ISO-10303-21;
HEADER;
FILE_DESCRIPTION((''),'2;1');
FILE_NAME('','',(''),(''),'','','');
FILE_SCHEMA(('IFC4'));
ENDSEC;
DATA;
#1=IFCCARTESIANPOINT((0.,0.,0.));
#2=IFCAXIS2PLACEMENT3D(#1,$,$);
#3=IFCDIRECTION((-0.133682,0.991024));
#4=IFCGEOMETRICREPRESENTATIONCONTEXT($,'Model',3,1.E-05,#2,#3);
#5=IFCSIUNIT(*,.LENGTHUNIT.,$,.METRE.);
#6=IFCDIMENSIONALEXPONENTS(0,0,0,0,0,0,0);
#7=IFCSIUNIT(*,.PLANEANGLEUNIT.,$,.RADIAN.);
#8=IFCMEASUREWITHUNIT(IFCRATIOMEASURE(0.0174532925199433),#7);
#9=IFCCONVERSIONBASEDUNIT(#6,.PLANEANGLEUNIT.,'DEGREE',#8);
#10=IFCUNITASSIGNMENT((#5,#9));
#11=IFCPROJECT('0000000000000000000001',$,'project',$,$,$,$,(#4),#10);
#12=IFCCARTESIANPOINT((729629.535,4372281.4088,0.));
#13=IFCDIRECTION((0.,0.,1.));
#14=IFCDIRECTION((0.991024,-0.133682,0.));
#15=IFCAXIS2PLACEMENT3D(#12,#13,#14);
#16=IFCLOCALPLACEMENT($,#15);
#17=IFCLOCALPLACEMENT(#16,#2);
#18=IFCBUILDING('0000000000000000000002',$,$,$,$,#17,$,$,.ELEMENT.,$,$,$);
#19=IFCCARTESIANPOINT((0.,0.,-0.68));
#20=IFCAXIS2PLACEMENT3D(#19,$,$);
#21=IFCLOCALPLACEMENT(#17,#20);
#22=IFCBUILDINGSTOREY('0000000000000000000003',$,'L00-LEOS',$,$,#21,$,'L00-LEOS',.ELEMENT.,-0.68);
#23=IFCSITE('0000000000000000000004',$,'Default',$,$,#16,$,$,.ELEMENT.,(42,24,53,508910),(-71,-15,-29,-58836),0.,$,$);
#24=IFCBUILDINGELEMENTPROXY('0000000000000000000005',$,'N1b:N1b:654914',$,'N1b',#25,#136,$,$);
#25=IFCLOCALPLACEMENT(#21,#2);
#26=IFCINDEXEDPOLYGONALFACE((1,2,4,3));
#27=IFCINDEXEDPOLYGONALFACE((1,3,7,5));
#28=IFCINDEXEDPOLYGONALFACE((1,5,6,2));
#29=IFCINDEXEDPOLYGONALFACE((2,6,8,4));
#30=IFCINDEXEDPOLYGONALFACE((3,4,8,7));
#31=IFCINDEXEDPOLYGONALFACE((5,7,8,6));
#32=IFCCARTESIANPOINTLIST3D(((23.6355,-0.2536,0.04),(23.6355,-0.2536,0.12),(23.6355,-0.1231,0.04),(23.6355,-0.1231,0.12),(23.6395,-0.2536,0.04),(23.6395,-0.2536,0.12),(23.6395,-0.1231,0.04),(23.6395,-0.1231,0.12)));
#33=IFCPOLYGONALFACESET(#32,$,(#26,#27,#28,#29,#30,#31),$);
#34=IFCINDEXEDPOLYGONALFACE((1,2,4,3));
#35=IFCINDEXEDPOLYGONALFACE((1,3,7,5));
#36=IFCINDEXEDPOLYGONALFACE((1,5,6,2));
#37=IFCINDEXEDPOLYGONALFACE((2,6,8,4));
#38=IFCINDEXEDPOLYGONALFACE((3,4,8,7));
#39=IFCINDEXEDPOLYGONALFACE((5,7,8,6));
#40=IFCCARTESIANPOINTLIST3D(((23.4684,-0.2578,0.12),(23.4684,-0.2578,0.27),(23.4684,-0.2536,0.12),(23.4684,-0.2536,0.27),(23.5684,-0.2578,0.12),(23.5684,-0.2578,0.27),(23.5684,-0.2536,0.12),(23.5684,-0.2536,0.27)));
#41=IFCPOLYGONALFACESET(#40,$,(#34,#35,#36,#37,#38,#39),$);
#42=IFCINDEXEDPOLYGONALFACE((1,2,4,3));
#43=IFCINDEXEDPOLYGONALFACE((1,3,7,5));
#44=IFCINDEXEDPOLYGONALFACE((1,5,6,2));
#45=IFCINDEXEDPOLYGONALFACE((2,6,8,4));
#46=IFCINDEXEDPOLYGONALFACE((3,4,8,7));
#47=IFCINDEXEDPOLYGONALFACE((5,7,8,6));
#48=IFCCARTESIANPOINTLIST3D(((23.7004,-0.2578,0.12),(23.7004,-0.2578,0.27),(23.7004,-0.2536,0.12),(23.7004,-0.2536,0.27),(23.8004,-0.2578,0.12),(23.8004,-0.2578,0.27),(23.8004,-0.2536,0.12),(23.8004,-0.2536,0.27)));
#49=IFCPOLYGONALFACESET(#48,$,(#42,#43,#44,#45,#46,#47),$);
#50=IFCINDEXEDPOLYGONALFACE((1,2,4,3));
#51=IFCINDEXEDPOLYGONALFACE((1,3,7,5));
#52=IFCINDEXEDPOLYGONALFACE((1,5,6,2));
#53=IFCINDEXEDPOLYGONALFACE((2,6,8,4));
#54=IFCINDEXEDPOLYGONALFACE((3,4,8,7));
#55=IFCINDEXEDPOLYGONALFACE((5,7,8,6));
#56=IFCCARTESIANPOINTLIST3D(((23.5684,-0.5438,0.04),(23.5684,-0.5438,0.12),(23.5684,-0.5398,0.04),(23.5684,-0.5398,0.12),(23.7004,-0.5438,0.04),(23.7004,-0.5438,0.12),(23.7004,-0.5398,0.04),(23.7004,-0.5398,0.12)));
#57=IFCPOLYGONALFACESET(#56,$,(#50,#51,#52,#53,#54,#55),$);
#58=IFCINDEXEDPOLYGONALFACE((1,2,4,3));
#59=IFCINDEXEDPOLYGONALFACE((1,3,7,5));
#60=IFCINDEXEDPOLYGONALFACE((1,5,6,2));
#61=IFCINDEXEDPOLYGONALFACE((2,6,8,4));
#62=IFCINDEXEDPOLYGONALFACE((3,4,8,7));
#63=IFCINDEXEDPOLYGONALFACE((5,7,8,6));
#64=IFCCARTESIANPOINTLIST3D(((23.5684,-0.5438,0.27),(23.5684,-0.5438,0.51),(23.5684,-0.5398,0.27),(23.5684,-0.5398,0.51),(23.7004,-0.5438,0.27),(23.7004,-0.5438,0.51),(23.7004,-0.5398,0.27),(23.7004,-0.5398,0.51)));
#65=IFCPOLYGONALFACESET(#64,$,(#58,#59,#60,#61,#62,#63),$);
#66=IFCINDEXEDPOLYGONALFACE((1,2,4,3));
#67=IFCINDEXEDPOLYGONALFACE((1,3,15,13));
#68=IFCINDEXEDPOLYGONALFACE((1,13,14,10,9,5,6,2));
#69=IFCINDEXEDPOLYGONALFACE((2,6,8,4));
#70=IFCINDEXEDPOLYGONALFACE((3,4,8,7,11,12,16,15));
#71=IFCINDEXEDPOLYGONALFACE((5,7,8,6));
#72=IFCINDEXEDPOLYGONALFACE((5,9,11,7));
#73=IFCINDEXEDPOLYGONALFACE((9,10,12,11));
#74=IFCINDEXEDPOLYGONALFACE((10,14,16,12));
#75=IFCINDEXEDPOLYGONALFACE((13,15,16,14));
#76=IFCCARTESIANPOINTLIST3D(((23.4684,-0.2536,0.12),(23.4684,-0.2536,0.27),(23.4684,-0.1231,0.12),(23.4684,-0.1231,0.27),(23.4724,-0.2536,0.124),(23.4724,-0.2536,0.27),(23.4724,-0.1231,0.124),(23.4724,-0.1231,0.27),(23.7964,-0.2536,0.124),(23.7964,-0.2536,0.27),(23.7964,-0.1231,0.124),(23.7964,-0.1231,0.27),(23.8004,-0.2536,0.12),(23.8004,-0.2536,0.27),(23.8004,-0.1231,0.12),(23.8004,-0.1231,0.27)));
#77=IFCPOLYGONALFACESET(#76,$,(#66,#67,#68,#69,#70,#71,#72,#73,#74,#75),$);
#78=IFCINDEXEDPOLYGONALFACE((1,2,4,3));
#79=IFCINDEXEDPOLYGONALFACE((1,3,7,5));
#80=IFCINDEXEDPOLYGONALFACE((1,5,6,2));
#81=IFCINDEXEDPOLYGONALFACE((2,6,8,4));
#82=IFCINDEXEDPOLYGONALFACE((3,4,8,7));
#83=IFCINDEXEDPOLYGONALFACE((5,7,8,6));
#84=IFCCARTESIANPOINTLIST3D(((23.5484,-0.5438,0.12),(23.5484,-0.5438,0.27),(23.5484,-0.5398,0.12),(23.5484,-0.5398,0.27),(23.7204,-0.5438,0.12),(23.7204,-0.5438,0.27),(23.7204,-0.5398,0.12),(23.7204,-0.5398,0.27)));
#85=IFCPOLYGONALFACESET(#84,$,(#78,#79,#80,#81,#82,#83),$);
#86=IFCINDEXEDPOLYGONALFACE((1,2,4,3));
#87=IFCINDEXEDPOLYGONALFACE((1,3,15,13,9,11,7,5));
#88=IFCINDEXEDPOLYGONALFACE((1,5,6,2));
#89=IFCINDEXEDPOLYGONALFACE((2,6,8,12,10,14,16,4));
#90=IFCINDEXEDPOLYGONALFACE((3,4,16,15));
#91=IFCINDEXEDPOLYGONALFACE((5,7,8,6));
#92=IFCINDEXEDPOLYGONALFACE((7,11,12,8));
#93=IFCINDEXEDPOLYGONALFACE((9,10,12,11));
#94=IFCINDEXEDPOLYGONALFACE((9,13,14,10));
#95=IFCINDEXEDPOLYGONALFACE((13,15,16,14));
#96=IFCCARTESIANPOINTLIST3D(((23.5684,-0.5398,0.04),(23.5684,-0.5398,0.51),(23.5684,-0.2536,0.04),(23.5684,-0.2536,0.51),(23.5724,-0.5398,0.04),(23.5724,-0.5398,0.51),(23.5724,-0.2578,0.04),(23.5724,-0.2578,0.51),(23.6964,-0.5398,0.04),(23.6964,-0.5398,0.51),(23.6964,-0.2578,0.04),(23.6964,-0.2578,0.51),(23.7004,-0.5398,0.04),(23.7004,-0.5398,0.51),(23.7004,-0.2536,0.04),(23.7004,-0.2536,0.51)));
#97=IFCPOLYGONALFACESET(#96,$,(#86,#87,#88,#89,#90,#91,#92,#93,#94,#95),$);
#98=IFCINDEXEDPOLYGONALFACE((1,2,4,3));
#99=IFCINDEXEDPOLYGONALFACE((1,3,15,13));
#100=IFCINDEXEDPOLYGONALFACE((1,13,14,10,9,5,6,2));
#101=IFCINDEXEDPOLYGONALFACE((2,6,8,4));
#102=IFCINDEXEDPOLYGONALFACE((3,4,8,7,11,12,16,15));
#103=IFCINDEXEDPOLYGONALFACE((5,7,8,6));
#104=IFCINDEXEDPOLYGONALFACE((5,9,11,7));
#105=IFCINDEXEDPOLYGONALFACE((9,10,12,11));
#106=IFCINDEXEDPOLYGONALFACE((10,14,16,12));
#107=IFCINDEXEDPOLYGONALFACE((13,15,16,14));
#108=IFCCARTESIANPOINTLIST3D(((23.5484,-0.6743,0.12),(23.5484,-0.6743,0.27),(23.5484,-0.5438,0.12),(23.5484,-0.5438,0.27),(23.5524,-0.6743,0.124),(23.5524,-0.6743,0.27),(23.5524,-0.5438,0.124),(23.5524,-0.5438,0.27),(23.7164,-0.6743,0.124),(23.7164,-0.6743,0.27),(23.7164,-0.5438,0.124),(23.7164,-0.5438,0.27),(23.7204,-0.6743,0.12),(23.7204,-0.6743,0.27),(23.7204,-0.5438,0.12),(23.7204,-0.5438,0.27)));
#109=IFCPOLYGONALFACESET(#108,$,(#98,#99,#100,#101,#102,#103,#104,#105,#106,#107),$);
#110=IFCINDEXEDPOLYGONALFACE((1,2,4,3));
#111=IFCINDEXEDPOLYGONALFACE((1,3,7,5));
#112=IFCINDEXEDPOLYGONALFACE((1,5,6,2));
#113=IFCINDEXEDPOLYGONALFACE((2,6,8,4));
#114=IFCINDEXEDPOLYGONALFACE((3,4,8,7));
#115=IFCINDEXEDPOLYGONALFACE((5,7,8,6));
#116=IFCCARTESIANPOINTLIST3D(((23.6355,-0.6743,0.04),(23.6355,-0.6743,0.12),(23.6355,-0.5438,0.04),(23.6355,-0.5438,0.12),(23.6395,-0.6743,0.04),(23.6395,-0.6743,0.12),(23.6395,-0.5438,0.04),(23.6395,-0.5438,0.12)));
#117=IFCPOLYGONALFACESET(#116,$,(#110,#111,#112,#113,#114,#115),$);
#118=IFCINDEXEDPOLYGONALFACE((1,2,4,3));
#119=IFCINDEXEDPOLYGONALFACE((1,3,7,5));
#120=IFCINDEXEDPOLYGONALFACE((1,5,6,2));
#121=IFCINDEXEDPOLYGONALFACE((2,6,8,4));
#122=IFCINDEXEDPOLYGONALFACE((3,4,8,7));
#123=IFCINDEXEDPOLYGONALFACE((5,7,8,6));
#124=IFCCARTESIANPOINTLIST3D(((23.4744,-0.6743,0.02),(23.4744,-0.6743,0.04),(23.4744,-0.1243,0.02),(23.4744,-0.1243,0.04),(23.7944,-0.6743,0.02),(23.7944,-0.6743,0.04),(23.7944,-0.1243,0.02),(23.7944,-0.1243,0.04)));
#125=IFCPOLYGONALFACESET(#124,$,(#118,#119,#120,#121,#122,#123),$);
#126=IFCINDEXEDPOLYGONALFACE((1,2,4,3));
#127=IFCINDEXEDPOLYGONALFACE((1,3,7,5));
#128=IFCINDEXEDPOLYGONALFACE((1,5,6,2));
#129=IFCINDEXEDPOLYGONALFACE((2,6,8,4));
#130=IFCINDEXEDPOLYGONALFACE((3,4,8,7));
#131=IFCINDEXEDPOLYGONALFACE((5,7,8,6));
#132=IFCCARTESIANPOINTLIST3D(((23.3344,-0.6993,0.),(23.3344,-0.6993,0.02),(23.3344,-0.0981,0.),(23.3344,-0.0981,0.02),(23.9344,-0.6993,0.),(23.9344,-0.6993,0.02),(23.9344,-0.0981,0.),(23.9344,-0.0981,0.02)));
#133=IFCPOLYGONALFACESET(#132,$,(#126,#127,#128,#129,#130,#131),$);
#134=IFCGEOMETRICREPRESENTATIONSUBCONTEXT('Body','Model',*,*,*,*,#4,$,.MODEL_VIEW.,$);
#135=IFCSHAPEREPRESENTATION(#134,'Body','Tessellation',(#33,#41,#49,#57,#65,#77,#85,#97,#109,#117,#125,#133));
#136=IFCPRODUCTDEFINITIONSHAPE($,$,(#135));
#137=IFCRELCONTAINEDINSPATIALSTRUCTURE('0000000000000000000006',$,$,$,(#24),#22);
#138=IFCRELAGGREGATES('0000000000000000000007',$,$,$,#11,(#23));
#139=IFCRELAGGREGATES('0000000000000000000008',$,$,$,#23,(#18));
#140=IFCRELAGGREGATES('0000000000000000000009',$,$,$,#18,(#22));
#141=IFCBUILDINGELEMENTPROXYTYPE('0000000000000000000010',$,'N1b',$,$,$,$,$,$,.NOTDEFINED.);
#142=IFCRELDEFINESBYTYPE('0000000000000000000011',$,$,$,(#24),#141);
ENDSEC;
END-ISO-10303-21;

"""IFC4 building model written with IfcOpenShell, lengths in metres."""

from ifc_helpers import new_model, entity, si_unit, converted_unit, direction, frame, frame_2d, origin, origin_2d_with_axis, place, context, subcontext, project, spatial, polyline, rectangle, outline, extrude, source, transform, mapped, type_object, type_shapes, element, save


model = new_model("IFC4")

# Units and contexts
model_context = context("Model", 3, precision=1e-05, world=origin(), true_north=direction((-0.133682, 0.991024)))
body_context = subcontext(model_context, "Body", "Model", "MODEL_VIEW")
ifc_project = project(units=[si_unit("LENGTHUNIT", "METRE"), converted_unit("PLANEANGLEUNIT", "DEGREE", entity("IfcRatioMeasure", 0.0174532925199433), si_unit("PLANEANGLEUNIT", "RADIAN"), dimensions=[0, 0, 0, 0, 0, 0, 0])], contexts=[model_context])

# Site, building, storey
site_placement = place(None, frame((729629.535, 4372281.4088, 0.0), z_axis=(0.0, 0.0, 1.0), x_axis=(0.991024, -0.133682, 0.0)))
site = spatial("IfcSite", under=ifc_project, at=site_placement, Name="Default", CompositionType="ELEMENT", RefLatitude=(42, 24, 53, 508910), RefLongitude=(-71, -15, -29, -58836), RefElevation=0.0)
building_placement = place(site_placement, origin())
building = spatial("IfcBuilding", under=site, at=building_placement, CompositionType="ELEMENT")
storey_placement = place(building_placement, frame((0.0, 0.0, -0.68)))
storey = spatial("IfcBuildingStorey", under=building, at=storey_placement, Name="L00-LEOS", LongName="L00-LEOS", CompositionType="ELEMENT", Elevation=-0.68)

# Building element proxy
building_element_proxy_type_1 = type_object("IfcBuildingElementProxyType", Name="N1b")
shared_shape_1 = source(origin(), body_context, "Body", "SweptSolid", [
    extrude(rectangle(XDim=0.004, YDim=0.1305, at=origin_2d_with_axis()), frame((0.2103, 0.0, 0.04), z_axis=(0.0, 0.0, 1.0), x_axis=(0.0, -1.0, 0.0)), (0.0, 0.0, 1.0), 0.08),
    extrude(rectangle(XDim=0.1, YDim=0.0042, at=frame_2d((0.0, 0.0), x_axis=(1.0, 0.0))), frame((0.143, 0.1191, 0.12), z_axis=(0.0, 0.0, 1.0), x_axis=(0.0, 1.0, 0.0)), (0.0, 0.0, 1.0), 0.15),
    extrude(rectangle(XDim=0.1, YDim=0.0042, at=origin_2d_with_axis()), frame((0.143, -0.1129, 0.12), z_axis=(0.0, 0.0, 1.0), x_axis=(0.0, 1.0, 0.0)), (0.0, 0.0, 1.0), 0.15),
    extrude(rectangle(XDim=0.132, YDim=0.004, at=frame_2d((0.0, 0.0), x_axis=(1.0, 0.0))), frame((-0.1431, 0.0031, 0.04), z_axis=(0.0, 0.0, 1.0), x_axis=(0.0, 1.0, 0.0)), (0.0, 0.0, 1.0), 0.08),
    extrude(rectangle(XDim=0.132, YDim=0.004, at=frame_2d((0.0, 0.0), x_axis=(1.0, 0.0))), frame((-0.1431, 0.0031, 0.27), z_axis=(0.0, 0.0, 1.0), x_axis=(0.0, 1.0, 0.0)), (0.0, 0.0, 1.0), 0.24),
    extrude(outline(polyline([(-0.076, -0.166), (0.074, -0.166), (0.074, -0.162), (-0.072, -0.162), (-0.072, 0.162), (0.074, 0.162), (0.074, 0.166), (-0.076, 0.166), (-0.076, -0.166)])), frame((0.1451, 0.0031, 0.196), z_axis=(1.0, 0.0, 0.0), x_axis=(0.0, 0.0, 1.0)), (0.0, 0.0, 1.0), 0.1305),
    extrude(rectangle(XDim=0.172, YDim=0.004, at=frame_2d((0.0, 0.0), x_axis=(1.0, 0.0))), frame((-0.1431, 0.0031, 0.12), z_axis=(0.0, 0.0, 1.0), x_axis=(0.0, 1.0, 0.0)), (0.0, 0.0, 1.0), 0.15),
    extrude(outline(polyline([(-0.1441, -0.066), (0.142, -0.066), (0.142, -0.062), (-0.14, -0.062), (-0.14, 0.062), (0.142, 0.062), (0.142, 0.066), (-0.1441, 0.066), (-0.1441, -0.066)])), frame((0.001, 0.0031, 0.04), z_axis=(0.0, 0.0, 1.0), x_axis=(-1.0, 0.0, 0.0)), (0.0, 0.0, 1.0), 0.47),
    extrude(outline(polyline([(-0.076, -0.086), (0.074, -0.086), (0.074, -0.082), (-0.072, -0.082), (-0.072, 0.082), (0.074, 0.082), (0.074, 0.086), (-0.076, 0.086), (-0.076, -0.086)])), frame((-0.2756, 0.0031, 0.196), z_axis=(1.0, 0.0, 0.0), x_axis=(0.0, 0.0, 1.0)), (0.0, 0.0, 1.0), 0.1305),
    extrude(rectangle(XDim=0.004, YDim=0.1305, at=origin_2d_with_axis()), frame((-0.2103, 0.0, 0.04), z_axis=(0.0, 0.0, 1.0), x_axis=(0.0, -1.0, 0.0)), (0.0, 0.0, 1.0), 0.08),
    extrude(rectangle(XDim=0.55, YDim=0.32, at=frame_2d((0.0, 0.0), x_axis=(1.0, 0.0))), frame((-0.0006, 0.0031, 0.02), z_axis=(0.0, 0.0, 1.0), x_axis=(-1.0, 0.0, 0.0)), (0.0, 0.0, 1.0), 0.02),
    extrude(rectangle(XDim=0.6012, YDim=0.6, at=frame_2d((0.0, 0.0), x_axis=(1.0, 0.0))), frame((0.0, 0.0031, 0.0), z_axis=(0.0, 0.0, 1.0), x_axis=(-1.0, 0.0, 0.0)), (0.0, 0.0, 1.0), 0.02),
])
type_shapes(building_element_proxy_type_1, [shared_shape_1])
for number, where, z_axis, x_axis, name in (
    (1, (23.6375, -0.3987, 0.0), (0.0, 0.0, 1.0), (0.0, 1.0, 0.0), "N1b:N1b:654914"),
):
    element("IfcBuildingElementProxy", number, at=place(storey_placement, frame(where, z_axis=z_axis, x_axis=x_axis)), inside=storey, type_object=building_element_proxy_type_1, Name=name, ObjectType="N1b", context=body_context, shape_type="MappedRepresentation", body=[
        mapped(shared_shape_1, transform((0.0, 0.0, 0.0), scale=1.0)),
    ])

save(model, "model.ifc")
